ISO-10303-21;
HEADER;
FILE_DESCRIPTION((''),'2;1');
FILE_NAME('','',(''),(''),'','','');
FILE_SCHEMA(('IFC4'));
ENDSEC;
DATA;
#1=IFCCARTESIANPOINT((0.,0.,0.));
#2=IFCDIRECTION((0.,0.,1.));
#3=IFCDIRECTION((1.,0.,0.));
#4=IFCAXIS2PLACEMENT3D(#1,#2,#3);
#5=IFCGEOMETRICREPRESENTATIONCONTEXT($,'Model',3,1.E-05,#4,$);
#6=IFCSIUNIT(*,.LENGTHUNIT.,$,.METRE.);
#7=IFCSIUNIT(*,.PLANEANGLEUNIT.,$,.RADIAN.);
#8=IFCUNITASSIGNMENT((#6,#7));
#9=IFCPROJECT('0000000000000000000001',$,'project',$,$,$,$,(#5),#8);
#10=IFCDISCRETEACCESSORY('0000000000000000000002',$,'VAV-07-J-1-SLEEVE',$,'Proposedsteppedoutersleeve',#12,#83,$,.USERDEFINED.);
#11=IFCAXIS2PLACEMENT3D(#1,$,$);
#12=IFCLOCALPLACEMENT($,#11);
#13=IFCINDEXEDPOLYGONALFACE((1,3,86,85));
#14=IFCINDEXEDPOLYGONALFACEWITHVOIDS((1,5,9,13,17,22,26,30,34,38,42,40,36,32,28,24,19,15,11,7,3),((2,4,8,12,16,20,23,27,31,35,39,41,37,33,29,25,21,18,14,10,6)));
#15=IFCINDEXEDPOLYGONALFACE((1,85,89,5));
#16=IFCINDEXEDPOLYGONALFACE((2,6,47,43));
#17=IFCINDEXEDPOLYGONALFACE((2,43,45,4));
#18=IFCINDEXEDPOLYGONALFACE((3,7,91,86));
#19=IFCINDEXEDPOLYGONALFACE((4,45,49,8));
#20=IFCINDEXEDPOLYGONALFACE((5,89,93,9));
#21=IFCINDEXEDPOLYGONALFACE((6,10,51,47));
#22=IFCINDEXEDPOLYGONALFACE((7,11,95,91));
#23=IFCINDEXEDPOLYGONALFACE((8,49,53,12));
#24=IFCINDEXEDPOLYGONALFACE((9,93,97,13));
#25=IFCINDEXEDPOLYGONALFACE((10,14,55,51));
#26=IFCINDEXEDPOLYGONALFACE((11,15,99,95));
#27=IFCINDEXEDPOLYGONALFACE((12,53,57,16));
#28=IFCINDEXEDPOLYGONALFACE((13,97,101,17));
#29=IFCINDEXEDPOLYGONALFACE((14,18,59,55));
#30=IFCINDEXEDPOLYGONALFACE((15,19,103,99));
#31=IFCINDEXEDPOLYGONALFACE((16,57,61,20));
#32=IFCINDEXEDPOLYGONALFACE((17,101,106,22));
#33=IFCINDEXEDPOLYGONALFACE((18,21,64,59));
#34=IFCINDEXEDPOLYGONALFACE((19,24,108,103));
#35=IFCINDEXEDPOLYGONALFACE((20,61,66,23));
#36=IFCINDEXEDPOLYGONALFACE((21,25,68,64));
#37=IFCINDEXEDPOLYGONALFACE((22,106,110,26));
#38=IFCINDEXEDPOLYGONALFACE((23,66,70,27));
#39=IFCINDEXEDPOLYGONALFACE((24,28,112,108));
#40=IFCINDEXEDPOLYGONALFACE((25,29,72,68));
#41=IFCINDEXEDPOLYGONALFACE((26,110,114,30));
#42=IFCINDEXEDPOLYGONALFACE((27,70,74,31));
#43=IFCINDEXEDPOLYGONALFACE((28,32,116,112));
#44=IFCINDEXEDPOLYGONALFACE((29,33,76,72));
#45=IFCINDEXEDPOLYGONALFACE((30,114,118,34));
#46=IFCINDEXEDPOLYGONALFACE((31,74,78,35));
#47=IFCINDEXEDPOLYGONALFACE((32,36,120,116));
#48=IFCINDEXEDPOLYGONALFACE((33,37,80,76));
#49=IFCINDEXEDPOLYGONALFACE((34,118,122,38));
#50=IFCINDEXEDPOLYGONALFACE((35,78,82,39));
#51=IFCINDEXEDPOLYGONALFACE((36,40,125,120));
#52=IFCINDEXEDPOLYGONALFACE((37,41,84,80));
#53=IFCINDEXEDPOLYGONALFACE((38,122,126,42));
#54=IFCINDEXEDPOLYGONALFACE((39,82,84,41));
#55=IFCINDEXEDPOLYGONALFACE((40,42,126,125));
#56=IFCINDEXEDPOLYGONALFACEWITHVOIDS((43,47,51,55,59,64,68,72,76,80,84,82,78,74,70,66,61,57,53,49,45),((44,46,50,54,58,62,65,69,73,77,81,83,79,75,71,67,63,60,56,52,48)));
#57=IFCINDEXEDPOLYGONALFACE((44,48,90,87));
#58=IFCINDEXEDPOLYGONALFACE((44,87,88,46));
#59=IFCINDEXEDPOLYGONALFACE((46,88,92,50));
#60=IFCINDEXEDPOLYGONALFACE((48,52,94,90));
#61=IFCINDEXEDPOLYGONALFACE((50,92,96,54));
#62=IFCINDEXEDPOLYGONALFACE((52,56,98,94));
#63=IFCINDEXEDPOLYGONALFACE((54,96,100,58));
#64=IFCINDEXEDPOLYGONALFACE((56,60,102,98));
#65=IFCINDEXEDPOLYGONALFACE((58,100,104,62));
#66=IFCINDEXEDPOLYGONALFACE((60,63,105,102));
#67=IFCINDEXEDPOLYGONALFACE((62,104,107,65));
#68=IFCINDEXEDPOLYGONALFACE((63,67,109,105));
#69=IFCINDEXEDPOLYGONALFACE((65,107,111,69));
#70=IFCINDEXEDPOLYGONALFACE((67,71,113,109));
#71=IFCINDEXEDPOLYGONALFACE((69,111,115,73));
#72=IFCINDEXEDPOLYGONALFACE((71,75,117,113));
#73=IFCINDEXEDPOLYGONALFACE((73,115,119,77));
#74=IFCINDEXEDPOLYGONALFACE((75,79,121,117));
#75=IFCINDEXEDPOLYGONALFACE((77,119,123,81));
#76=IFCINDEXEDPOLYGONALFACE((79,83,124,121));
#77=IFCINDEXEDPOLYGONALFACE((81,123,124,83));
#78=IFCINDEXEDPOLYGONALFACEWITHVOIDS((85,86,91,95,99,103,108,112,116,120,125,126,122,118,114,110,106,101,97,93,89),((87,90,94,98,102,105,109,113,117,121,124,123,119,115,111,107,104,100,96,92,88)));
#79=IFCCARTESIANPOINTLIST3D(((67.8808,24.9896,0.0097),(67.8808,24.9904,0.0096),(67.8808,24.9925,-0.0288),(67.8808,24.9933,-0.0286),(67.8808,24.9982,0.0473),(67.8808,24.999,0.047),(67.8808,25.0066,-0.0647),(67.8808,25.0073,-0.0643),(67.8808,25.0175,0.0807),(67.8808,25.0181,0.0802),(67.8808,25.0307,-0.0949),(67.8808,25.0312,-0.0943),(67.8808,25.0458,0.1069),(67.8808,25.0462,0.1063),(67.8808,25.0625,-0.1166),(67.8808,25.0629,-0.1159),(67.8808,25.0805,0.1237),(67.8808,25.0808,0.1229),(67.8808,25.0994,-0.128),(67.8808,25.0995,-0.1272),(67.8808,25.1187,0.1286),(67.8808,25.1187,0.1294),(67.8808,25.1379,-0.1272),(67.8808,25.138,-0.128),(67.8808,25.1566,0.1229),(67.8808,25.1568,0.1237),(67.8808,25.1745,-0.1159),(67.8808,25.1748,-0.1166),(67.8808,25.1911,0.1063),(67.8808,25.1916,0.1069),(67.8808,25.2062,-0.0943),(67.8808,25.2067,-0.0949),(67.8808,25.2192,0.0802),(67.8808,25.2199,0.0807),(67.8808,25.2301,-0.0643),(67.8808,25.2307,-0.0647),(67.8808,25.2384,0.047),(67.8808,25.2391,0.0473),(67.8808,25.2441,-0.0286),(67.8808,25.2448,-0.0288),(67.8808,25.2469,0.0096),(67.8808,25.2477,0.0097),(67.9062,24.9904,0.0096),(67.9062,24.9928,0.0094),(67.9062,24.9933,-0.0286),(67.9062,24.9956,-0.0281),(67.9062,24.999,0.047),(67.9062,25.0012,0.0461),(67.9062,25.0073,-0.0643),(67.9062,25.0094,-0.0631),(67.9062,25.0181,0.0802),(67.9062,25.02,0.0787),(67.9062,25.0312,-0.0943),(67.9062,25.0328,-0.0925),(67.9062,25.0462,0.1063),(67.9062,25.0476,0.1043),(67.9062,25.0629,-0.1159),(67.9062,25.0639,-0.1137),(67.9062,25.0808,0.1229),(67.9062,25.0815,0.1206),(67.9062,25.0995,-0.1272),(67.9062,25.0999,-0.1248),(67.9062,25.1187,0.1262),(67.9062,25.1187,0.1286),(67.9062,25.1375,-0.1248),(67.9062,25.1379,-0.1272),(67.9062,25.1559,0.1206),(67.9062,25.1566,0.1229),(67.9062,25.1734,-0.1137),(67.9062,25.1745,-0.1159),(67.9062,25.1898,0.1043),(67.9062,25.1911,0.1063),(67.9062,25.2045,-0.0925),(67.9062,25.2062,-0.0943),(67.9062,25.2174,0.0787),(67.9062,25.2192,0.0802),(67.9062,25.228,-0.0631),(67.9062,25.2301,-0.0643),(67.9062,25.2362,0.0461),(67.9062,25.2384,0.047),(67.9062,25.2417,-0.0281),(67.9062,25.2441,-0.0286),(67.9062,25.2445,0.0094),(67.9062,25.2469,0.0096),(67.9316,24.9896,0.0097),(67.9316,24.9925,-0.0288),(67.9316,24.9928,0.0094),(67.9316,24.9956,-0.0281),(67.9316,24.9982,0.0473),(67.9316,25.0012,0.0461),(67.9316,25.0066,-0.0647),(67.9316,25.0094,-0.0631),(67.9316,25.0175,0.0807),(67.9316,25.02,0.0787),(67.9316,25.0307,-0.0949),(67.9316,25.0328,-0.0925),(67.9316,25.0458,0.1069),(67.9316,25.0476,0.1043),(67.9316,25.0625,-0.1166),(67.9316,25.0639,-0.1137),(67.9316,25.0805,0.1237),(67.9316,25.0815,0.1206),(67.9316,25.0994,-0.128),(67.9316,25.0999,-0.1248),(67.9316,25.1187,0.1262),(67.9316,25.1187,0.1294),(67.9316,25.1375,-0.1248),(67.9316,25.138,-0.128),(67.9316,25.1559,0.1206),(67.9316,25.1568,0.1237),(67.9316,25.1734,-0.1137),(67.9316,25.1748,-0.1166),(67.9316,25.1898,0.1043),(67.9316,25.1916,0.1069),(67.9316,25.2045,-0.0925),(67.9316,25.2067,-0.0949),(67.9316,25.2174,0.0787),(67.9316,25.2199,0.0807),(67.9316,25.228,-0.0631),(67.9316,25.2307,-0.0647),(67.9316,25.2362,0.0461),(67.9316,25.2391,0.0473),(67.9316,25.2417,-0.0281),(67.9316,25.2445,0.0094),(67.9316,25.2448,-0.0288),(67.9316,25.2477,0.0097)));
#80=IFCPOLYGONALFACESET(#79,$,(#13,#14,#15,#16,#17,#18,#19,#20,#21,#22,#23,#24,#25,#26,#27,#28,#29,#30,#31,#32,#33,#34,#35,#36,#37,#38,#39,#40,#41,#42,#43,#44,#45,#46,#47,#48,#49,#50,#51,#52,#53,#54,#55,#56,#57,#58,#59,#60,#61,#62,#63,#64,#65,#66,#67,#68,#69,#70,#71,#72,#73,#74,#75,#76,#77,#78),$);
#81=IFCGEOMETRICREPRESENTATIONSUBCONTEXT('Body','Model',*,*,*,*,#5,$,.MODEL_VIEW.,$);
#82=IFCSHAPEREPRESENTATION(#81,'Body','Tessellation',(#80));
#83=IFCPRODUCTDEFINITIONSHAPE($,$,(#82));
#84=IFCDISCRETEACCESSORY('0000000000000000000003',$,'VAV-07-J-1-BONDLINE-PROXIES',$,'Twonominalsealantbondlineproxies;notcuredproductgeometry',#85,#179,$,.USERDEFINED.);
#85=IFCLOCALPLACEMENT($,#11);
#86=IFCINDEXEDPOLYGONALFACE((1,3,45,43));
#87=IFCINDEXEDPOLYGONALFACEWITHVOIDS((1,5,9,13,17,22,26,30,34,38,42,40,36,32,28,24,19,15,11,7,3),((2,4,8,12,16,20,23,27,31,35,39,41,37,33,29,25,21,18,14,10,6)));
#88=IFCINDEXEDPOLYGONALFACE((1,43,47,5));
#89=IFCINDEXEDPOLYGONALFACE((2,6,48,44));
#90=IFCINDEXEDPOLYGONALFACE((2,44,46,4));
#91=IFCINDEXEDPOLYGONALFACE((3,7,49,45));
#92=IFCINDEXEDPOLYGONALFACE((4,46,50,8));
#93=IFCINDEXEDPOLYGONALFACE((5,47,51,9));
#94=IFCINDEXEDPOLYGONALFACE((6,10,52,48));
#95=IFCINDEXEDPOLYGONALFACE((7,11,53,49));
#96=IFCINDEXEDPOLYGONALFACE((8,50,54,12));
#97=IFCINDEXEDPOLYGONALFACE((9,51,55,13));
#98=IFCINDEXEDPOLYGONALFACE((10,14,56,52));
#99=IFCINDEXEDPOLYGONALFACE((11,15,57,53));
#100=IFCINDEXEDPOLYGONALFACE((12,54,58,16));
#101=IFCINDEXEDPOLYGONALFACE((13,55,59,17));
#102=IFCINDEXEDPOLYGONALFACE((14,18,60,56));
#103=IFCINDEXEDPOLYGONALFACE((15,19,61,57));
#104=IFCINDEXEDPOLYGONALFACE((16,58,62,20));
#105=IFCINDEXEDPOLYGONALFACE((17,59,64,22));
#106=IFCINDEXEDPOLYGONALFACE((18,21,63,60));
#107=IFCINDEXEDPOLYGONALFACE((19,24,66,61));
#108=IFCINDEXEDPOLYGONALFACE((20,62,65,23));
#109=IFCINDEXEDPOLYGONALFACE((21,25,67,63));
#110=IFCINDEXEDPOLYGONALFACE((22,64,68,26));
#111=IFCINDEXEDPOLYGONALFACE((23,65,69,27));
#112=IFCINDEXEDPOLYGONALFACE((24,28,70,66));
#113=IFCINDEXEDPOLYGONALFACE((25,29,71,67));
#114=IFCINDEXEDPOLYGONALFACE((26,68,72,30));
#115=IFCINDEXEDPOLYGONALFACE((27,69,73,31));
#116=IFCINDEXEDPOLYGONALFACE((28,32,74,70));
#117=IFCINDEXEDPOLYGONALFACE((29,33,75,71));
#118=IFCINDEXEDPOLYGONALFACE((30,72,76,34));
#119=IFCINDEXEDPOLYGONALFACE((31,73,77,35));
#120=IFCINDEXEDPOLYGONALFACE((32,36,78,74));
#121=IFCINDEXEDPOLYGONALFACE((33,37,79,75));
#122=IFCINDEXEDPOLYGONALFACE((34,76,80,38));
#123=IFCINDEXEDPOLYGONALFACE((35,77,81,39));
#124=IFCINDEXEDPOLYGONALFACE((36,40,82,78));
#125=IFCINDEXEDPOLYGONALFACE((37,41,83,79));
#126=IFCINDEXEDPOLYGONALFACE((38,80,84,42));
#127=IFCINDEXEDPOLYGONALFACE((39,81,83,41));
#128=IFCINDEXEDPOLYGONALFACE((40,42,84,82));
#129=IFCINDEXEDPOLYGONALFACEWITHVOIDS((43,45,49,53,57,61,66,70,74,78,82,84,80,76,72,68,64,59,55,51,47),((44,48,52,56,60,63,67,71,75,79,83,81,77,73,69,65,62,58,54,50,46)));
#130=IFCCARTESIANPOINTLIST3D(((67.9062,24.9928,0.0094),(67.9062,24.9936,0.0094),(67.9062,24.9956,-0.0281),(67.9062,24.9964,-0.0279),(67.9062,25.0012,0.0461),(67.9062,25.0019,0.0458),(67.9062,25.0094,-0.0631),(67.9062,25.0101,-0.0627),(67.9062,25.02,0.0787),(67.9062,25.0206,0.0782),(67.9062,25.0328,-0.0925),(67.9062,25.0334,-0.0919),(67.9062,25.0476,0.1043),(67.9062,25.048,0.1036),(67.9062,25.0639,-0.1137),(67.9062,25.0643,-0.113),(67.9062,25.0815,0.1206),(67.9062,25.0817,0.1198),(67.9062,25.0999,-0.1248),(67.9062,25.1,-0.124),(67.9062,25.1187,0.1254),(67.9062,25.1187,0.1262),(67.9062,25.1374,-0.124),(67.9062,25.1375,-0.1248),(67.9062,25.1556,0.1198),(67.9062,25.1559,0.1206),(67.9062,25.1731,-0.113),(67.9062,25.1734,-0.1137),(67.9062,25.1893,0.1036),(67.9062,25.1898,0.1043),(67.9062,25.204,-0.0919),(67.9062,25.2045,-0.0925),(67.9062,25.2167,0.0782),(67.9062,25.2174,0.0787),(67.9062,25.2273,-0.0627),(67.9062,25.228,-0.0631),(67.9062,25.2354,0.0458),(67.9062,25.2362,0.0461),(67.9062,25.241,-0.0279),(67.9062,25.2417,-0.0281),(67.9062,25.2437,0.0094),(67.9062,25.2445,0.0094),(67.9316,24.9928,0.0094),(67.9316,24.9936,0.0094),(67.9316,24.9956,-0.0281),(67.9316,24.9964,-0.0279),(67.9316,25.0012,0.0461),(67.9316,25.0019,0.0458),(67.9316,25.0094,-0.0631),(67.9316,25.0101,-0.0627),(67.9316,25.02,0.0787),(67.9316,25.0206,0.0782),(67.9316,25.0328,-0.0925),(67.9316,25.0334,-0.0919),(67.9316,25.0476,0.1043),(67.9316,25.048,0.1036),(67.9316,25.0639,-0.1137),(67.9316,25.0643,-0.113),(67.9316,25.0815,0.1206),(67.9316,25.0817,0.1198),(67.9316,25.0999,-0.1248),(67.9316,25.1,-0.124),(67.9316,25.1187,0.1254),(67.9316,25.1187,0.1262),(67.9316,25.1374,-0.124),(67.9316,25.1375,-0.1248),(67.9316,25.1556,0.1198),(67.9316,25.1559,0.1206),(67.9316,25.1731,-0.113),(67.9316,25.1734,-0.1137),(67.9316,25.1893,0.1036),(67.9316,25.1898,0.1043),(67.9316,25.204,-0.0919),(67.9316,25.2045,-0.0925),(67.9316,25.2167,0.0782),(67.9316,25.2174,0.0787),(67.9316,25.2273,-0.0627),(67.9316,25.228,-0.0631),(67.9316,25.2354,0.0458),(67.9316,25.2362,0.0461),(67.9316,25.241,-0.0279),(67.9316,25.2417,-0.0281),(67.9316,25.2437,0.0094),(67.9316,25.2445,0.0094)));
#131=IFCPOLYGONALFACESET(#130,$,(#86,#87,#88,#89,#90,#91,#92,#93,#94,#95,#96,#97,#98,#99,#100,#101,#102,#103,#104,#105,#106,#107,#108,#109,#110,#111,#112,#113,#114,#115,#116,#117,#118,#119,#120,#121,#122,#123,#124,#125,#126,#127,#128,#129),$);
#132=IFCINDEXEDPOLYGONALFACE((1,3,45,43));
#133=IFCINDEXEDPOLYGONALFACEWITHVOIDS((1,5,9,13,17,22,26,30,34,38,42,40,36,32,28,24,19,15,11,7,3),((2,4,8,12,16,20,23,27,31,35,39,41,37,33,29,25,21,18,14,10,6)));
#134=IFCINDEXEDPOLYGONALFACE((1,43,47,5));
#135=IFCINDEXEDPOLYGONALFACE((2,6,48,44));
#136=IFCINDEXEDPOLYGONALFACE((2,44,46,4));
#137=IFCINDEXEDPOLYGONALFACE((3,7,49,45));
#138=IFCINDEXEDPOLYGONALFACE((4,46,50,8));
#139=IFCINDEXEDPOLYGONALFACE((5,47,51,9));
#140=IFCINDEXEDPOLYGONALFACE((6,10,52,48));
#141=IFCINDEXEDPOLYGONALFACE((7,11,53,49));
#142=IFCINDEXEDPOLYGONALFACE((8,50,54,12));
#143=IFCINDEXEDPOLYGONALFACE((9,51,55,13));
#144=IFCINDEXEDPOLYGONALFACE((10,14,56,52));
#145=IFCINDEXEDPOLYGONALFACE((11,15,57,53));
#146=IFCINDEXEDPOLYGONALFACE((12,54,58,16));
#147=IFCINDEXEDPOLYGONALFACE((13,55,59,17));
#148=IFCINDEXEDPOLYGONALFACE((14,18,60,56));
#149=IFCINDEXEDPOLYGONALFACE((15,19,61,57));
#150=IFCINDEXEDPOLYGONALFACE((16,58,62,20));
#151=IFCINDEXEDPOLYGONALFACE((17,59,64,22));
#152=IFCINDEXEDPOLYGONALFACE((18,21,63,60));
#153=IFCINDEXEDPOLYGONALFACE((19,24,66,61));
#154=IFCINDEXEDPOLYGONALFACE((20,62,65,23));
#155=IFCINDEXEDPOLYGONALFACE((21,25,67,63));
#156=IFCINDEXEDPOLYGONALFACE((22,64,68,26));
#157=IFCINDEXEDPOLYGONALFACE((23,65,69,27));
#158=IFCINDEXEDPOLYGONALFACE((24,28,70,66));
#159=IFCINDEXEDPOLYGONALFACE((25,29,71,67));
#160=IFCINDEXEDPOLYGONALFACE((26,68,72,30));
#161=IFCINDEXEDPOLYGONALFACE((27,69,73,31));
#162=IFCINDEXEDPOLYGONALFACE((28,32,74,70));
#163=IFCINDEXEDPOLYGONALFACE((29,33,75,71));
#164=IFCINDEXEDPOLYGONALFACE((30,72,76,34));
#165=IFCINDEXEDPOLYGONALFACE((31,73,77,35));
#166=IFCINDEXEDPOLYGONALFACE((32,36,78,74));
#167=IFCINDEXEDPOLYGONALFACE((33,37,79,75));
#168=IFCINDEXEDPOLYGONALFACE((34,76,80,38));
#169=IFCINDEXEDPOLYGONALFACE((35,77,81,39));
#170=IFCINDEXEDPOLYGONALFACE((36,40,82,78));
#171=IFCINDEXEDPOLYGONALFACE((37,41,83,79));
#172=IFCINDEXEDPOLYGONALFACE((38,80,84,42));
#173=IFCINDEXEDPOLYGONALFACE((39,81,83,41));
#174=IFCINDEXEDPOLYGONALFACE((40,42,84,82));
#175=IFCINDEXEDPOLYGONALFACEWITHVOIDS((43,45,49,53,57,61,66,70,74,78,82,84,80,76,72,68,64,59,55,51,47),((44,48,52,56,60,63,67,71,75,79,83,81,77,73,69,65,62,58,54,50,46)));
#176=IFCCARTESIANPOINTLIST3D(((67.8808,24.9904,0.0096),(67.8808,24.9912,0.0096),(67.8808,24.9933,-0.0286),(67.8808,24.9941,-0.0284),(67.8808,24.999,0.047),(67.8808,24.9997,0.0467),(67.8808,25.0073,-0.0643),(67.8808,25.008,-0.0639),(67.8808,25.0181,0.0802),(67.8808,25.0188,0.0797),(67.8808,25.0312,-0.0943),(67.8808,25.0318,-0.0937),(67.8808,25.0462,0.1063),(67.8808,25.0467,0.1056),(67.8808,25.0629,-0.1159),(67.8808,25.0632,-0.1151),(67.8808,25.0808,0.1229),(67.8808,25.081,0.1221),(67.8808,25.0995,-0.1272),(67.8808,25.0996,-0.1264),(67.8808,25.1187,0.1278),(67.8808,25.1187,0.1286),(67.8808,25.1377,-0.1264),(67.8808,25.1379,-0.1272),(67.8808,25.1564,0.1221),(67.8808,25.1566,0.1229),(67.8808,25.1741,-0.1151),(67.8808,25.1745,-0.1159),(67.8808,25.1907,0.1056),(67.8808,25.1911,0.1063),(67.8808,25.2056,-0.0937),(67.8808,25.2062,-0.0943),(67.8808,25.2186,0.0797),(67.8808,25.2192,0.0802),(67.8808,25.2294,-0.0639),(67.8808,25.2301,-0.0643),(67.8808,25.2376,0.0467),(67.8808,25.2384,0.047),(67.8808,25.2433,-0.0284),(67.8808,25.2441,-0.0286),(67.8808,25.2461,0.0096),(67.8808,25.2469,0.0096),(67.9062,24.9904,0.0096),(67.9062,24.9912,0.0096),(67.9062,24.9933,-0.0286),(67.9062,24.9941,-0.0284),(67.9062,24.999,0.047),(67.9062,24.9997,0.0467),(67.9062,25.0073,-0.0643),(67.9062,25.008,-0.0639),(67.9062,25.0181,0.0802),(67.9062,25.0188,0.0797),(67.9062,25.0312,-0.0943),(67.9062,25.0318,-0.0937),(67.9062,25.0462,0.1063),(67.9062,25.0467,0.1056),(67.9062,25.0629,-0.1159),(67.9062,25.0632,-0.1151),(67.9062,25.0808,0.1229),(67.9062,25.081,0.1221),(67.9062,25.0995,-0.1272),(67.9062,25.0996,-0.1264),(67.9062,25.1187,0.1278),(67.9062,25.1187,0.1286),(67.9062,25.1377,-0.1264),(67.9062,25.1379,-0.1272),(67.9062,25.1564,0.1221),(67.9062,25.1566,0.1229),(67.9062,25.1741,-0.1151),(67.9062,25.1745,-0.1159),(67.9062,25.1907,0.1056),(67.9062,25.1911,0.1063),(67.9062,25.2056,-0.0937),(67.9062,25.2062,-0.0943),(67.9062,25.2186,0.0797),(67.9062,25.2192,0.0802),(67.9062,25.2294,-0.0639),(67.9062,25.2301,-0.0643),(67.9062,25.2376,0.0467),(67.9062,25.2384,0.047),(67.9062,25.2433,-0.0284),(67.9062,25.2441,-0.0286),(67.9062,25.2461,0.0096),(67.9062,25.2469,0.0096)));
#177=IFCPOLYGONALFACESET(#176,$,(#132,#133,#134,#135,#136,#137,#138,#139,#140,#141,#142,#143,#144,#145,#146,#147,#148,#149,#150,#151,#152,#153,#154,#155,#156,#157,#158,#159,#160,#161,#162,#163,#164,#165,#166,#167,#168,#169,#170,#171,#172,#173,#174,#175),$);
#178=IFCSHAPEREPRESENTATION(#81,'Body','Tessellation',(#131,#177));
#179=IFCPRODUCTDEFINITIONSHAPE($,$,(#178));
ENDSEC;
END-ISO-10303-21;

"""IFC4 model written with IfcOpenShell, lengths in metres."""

from ifc_helpers import new_model, entity, si_unit, frame, origin_with_axes, place, context, subcontext, project, element, save


model = new_model("IFC4")

# Units and contexts
model_context = context("Model", 3, precision=1e-05, world=origin_with_axes())
body_context = subcontext(model_context, "Body", "Model", "MODEL_VIEW")
ifc_project = project(units=[si_unit("LENGTHUNIT", "METRE"), si_unit("PLANEANGLEUNIT", "RADIAN")], contexts=[model_context])

# Discrete accessories
discrete_accessory_1_placement = place(None, frame((67.9062, 25.1187, 0.0), z_axis=(0.0, -1.0, 0.0), x_axis=(0.0, 0.0, 1.0)))
element("IfcDiscreteAccessory", 1, at=discrete_accessory_1_placement, Name="VAV-07-J-1-SLEEVE", ObjectType="Proposedsteppedoutersleeve", PredefinedType="USERDEFINED", context=body_context, shape_type="SweptSolid", body=[
    entity("IfcRevolvedAreaSolid", entity("IfcArbitraryClosedProfileDef", "AREA", None, entity("IfcPolyline", [entity("IfcCartesianPoint", [0.1262, -0.0254]), entity("IfcCartesianPoint", [0.1294, -0.0254]), entity("IfcCartesianPoint", [0.1294, 0.0254]), entity("IfcCartesianPoint", [0.1286, 0.0254]), entity("IfcCartesianPoint", [0.1286, 0.0]), entity("IfcCartesianPoint", [0.1262, 0.0]), entity("IfcCartesianPoint", [0.1262, -0.0254])])), entity("IfcAxis2Placement3D", entity("IfcCartesianPoint", [0.0, 0.0, 0.0])), entity("IfcAxis1Placement", entity("IfcCartesianPoint", [0.0, 0.0, 0.0]), entity("IfcDirection", [0.0, 1.0, 0.0])), 6.283185),
])
discrete_accessory_2_placement = place(None, frame((67.9062, 25.1187, 0.0), z_axis=(0.0, -1.0, 0.0), x_axis=(0.0, 0.0, 1.0)))
element("IfcDiscreteAccessory", 2, at=discrete_accessory_2_placement, Name="VAV-07-J-1-BONDLINE-PROXIES", ObjectType="Twonominalsealantbondlineproxies;notcuredproductgeometry", PredefinedType="USERDEFINED", context=body_context, shape_type="SweptSolid", body=[
    entity("IfcRevolvedAreaSolid", entity("IfcArbitraryClosedProfileDef", "AREA", None, entity("IfcPolyline", [entity("IfcCartesianPoint", [0.1254, -0.0254]), entity("IfcCartesianPoint", [0.1262, -0.0254]), entity("IfcCartesianPoint", [0.1262, 0.0]), entity("IfcCartesianPoint", [0.1254, 0.0]), entity("IfcCartesianPoint", [0.1254, -0.0254])])), entity("IfcAxis2Placement3D", entity("IfcCartesianPoint", [0.0, 0.0, 0.0])), entity("IfcAxis1Placement", entity("IfcCartesianPoint", [0.0, 0.0, 0.0]), entity("IfcDirection", [0.0, 1.0, 0.0])), 6.283185),
    entity("IfcRevolvedAreaSolid", entity("IfcArbitraryClosedProfileDef", "AREA", None, entity("IfcPolyline", [entity("IfcCartesianPoint", [0.1278, 0.0]), entity("IfcCartesianPoint", [0.1286, 0.0]), entity("IfcCartesianPoint", [0.1286, 0.0254]), entity("IfcCartesianPoint", [0.1278, 0.0254]), entity("IfcCartesianPoint", [0.1278, 0.0])])), entity("IfcAxis2Placement3D", entity("IfcCartesianPoint", [0.0, 0.0, 0.0])), entity("IfcAxis1Placement", entity("IfcCartesianPoint", [0.0, 0.0, 0.0]), entity("IfcDirection", [0.0, 1.0, 0.0])), 6.283185),
])

save(model, "model.ifc")
